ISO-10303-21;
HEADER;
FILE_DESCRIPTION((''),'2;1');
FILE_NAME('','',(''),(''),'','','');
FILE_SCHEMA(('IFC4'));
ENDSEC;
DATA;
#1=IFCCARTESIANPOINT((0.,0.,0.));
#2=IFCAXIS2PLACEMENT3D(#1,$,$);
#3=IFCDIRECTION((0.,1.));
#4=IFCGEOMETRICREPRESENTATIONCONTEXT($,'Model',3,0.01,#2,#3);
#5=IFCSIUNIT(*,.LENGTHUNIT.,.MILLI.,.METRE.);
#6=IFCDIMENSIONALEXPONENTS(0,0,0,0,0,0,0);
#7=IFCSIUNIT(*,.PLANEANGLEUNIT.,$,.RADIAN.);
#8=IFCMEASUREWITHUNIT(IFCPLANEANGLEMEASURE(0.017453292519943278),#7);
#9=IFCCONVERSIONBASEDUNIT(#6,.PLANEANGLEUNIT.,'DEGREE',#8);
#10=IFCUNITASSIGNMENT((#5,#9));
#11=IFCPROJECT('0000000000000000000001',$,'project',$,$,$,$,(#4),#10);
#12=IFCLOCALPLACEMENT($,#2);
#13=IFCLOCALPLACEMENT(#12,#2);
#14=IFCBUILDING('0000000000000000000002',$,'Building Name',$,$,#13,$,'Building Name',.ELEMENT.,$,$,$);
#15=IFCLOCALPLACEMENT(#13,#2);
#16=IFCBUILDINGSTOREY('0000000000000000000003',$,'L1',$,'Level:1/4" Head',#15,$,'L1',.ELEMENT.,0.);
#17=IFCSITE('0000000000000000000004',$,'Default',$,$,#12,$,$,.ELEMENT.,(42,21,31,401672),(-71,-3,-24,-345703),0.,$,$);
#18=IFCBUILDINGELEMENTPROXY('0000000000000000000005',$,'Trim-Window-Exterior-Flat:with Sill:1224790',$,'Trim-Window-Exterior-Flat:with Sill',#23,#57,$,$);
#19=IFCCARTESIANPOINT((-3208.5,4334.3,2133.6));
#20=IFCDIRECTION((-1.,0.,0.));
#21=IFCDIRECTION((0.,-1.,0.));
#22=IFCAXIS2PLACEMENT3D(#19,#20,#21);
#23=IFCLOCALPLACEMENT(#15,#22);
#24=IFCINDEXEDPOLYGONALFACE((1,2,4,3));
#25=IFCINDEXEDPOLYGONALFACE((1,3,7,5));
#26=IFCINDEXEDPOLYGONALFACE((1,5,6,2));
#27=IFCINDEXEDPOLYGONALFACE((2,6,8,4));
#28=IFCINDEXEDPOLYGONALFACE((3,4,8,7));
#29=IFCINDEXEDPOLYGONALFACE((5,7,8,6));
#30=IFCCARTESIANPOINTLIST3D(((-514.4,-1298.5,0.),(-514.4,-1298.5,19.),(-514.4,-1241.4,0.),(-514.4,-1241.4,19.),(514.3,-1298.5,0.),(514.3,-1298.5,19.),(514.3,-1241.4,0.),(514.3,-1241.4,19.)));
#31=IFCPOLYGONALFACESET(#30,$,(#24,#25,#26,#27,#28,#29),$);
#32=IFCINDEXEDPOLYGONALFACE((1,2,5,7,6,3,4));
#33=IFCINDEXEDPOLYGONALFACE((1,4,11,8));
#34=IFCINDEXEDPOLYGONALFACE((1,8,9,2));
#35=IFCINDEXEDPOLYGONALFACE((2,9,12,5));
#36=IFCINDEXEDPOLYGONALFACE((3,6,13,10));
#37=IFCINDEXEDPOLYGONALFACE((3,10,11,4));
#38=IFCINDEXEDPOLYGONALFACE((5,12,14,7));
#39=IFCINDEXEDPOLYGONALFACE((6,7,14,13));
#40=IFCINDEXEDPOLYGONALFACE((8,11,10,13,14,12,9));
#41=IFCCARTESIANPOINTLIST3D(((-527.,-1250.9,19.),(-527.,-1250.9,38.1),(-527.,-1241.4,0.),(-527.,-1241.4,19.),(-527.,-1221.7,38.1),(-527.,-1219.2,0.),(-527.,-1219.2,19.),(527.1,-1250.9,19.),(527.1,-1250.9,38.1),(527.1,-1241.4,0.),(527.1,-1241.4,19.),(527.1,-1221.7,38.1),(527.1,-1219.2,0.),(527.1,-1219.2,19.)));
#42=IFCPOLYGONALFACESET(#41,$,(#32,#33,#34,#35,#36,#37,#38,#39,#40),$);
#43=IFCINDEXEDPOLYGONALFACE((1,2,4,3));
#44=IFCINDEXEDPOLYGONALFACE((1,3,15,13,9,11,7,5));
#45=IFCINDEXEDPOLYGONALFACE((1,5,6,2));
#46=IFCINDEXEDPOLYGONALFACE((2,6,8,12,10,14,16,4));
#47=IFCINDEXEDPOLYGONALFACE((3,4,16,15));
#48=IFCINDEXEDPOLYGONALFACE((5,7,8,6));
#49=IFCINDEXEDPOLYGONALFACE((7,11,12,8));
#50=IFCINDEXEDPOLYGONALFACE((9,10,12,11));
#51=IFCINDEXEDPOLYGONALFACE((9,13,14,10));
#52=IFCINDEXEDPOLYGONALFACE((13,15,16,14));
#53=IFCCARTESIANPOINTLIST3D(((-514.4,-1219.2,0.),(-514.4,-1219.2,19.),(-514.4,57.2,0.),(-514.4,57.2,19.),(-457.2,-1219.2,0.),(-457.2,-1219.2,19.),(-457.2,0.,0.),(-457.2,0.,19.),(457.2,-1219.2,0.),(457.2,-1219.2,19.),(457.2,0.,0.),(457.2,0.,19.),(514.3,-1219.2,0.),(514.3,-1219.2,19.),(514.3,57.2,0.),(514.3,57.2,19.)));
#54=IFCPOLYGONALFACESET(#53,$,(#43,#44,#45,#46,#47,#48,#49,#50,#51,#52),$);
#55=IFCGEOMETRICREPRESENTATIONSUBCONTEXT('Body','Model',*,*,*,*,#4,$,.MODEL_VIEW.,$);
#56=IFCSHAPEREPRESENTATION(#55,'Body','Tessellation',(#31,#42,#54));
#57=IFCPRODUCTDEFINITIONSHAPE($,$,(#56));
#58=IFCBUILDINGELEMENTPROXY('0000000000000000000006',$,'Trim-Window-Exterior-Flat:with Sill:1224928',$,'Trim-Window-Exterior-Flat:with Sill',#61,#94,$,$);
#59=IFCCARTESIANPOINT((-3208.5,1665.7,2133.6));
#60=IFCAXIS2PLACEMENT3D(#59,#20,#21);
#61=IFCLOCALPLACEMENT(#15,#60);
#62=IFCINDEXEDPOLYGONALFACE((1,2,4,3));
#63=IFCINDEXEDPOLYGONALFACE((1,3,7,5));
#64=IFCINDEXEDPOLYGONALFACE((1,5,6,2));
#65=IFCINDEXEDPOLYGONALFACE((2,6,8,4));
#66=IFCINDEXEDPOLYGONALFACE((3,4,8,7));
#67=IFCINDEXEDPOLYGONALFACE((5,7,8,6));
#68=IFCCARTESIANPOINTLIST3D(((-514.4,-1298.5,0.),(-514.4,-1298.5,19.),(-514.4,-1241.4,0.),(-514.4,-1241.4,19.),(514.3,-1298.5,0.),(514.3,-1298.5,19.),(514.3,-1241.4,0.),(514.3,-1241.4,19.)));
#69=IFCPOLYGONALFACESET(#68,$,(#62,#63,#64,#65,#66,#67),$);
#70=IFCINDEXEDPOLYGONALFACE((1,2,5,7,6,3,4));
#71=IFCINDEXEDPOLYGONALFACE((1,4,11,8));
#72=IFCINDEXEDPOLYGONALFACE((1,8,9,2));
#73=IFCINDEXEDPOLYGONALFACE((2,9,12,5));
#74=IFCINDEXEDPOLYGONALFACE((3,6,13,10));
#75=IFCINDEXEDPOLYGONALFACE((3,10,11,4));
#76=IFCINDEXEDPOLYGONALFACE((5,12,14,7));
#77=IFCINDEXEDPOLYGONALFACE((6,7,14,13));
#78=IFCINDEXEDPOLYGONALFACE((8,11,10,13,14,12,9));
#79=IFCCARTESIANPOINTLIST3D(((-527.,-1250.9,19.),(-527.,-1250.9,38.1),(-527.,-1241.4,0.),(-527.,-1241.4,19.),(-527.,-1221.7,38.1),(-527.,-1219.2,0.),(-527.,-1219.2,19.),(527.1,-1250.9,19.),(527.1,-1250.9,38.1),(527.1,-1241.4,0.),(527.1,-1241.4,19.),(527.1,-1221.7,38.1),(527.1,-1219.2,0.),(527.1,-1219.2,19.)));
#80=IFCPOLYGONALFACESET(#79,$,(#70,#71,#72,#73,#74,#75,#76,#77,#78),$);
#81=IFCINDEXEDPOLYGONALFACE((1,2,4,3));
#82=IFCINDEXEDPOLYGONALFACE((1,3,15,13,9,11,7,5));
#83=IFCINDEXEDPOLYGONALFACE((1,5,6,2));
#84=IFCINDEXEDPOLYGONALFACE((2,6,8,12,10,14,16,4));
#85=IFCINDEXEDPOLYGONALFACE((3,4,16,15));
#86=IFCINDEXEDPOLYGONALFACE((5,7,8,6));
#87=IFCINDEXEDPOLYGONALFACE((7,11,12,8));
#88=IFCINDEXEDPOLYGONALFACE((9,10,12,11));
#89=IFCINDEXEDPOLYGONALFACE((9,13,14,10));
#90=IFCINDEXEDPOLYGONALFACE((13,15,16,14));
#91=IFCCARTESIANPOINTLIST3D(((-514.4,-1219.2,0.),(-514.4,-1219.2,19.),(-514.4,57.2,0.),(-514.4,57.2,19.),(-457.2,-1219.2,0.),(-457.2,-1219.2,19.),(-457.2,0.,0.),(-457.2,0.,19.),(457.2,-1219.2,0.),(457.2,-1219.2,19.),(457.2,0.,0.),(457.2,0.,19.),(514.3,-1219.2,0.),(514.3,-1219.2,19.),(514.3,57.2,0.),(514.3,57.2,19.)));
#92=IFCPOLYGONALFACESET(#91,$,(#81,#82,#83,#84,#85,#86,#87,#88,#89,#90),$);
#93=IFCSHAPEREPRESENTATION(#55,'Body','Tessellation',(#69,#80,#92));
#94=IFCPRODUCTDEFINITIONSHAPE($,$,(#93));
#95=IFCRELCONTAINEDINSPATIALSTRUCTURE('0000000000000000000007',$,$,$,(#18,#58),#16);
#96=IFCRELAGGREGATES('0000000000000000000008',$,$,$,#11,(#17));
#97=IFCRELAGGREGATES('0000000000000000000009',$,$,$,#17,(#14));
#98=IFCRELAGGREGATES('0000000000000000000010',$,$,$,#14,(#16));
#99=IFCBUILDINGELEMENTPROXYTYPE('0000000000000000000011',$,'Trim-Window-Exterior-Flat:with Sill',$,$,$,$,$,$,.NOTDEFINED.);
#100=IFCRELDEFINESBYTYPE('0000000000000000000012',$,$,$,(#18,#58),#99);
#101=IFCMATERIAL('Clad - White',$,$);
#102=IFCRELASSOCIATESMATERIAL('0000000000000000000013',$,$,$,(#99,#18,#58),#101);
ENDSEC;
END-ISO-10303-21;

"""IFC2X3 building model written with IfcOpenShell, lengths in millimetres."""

from ifc_helpers import new_model, entity, si_unit, converted_unit, direction, frame, origin, origin_2d_with_axis, place, context, subcontext, project, spatial, polyline, rectangle, outline, extrude, source, transform, mapped, material, type_object, type_shapes, element, save


model = new_model("IFC2X3")

# Units and contexts
model_context = context("Model", 3, precision=0.01, world=origin(), true_north=direction((0.0, 1.0)))
body_context = subcontext(model_context, "Body", "Model", "MODEL_VIEW")
ifc_project = project(units=[si_unit("LENGTHUNIT", "METRE", prefix="MILLI"), converted_unit("PLANEANGLEUNIT", "DEGREE", entity("IfcPlaneAngleMeasure", 0.017453292519943278), si_unit("PLANEANGLEUNIT", "RADIAN"), dimensions=[0, 0, 0, 0, 0, 0, 0])], contexts=[model_context])

# Site, building, storey
site_placement = place(None, origin())
site = spatial("IfcSite", under=ifc_project, at=site_placement, Name="Default", CompositionType="ELEMENT", RefLatitude=(42, 21, 31, 401672), RefLongitude=(-71, -3, -24, -345703), RefElevation=0.0)
building_placement = place(site_placement, origin())
building = spatial("IfcBuilding", under=site, at=building_placement, Name="Building Name", LongName="Building Name", CompositionType="ELEMENT")
storey_placement = place(building_placement, origin())
storey = spatial("IfcBuildingStorey", under=building, at=storey_placement, Name="L1", ObjectType="Level:1/4\" Head", LongName="L1", CompositionType="ELEMENT", Elevation=0.0)

# Building element proxies
ifc_material_1 = material(Name="Clad - White")
building_element_proxy_type_1 = type_object("IfcBuildingElementProxyType", Name="Trim-Window-Exterior-Flat:with Sill", PredefinedType="NOTDEFINED", material=ifc_material_1)
shared_shape_1 = source(origin(), body_context, "Body", "SweptSolid", [
    extrude(rectangle(XDim=1028.7, YDim=57.2, at=origin_2d_with_axis()), frame((0.0, -1270.0, 0.0), z_axis=(0.0, 0.0, 1.0), x_axis=(-1.0, 0.0, 0.0)), (0.0, 0.0, 1.0), 19.0),
    extrude(outline(polyline([(-19.0, -16.0), (0.0, -16.0), (0.0, -6.4), (19.0, -6.4), (19.0, 15.8), (0.0, 15.8), (-19.0, 13.3), (-19.0, -16.0)])), frame((-527.0, -1235.0, 19.0), z_axis=(1.0, 0.0, 0.0), x_axis=(0.0, 0.0, -1.0)), (0.0, 0.0, 1.0), 1054.1),
    extrude(outline(polyline([(-652.5, -514.3), (623.9, -514.3), (623.9, -457.2), (-595.3, -457.2), (-595.3, 457.2), (623.9, 457.2), (623.9, 514.3), (-652.5, 514.3), (-652.5, -514.3)])), frame((0.0, -595.3, 0.0), z_axis=(0.0, 0.0, 1.0), x_axis=(0.0, -1.0, 0.0)), (0.0, 0.0, 1.0), 19.0),
])
type_shapes(building_element_proxy_type_1, [shared_shape_1])
for number, where, z_axis, x_axis, name in (
    (1, (-3208.5, 4334.3, 2133.6), (-1.0, 0.0, 0.0), (0.0, -1.0, 0.0), "Trim-Window-Exterior-Flat:with Sill:1224790"),
    (2, (-3208.5, 1665.7, 2133.6), (-1.0, 0.0, 0.0), (0.0, -1.0, 0.0), "Trim-Window-Exterior-Flat:with Sill:1224928"),
):
    element("IfcBuildingElementProxy", number, at=place(storey_placement, frame(where, z_axis=z_axis, x_axis=x_axis)), inside=storey, type_object=building_element_proxy_type_1, material=ifc_material_1, Name=name, ObjectType="Trim-Window-Exterior-Flat:with Sill", context=body_context, shape_type="MappedRepresentation", body=[
        mapped(shared_shape_1, transform((0.0, 0.0, 0.0), scale=1.0)),
    ])

save(model, "model.ifc")
